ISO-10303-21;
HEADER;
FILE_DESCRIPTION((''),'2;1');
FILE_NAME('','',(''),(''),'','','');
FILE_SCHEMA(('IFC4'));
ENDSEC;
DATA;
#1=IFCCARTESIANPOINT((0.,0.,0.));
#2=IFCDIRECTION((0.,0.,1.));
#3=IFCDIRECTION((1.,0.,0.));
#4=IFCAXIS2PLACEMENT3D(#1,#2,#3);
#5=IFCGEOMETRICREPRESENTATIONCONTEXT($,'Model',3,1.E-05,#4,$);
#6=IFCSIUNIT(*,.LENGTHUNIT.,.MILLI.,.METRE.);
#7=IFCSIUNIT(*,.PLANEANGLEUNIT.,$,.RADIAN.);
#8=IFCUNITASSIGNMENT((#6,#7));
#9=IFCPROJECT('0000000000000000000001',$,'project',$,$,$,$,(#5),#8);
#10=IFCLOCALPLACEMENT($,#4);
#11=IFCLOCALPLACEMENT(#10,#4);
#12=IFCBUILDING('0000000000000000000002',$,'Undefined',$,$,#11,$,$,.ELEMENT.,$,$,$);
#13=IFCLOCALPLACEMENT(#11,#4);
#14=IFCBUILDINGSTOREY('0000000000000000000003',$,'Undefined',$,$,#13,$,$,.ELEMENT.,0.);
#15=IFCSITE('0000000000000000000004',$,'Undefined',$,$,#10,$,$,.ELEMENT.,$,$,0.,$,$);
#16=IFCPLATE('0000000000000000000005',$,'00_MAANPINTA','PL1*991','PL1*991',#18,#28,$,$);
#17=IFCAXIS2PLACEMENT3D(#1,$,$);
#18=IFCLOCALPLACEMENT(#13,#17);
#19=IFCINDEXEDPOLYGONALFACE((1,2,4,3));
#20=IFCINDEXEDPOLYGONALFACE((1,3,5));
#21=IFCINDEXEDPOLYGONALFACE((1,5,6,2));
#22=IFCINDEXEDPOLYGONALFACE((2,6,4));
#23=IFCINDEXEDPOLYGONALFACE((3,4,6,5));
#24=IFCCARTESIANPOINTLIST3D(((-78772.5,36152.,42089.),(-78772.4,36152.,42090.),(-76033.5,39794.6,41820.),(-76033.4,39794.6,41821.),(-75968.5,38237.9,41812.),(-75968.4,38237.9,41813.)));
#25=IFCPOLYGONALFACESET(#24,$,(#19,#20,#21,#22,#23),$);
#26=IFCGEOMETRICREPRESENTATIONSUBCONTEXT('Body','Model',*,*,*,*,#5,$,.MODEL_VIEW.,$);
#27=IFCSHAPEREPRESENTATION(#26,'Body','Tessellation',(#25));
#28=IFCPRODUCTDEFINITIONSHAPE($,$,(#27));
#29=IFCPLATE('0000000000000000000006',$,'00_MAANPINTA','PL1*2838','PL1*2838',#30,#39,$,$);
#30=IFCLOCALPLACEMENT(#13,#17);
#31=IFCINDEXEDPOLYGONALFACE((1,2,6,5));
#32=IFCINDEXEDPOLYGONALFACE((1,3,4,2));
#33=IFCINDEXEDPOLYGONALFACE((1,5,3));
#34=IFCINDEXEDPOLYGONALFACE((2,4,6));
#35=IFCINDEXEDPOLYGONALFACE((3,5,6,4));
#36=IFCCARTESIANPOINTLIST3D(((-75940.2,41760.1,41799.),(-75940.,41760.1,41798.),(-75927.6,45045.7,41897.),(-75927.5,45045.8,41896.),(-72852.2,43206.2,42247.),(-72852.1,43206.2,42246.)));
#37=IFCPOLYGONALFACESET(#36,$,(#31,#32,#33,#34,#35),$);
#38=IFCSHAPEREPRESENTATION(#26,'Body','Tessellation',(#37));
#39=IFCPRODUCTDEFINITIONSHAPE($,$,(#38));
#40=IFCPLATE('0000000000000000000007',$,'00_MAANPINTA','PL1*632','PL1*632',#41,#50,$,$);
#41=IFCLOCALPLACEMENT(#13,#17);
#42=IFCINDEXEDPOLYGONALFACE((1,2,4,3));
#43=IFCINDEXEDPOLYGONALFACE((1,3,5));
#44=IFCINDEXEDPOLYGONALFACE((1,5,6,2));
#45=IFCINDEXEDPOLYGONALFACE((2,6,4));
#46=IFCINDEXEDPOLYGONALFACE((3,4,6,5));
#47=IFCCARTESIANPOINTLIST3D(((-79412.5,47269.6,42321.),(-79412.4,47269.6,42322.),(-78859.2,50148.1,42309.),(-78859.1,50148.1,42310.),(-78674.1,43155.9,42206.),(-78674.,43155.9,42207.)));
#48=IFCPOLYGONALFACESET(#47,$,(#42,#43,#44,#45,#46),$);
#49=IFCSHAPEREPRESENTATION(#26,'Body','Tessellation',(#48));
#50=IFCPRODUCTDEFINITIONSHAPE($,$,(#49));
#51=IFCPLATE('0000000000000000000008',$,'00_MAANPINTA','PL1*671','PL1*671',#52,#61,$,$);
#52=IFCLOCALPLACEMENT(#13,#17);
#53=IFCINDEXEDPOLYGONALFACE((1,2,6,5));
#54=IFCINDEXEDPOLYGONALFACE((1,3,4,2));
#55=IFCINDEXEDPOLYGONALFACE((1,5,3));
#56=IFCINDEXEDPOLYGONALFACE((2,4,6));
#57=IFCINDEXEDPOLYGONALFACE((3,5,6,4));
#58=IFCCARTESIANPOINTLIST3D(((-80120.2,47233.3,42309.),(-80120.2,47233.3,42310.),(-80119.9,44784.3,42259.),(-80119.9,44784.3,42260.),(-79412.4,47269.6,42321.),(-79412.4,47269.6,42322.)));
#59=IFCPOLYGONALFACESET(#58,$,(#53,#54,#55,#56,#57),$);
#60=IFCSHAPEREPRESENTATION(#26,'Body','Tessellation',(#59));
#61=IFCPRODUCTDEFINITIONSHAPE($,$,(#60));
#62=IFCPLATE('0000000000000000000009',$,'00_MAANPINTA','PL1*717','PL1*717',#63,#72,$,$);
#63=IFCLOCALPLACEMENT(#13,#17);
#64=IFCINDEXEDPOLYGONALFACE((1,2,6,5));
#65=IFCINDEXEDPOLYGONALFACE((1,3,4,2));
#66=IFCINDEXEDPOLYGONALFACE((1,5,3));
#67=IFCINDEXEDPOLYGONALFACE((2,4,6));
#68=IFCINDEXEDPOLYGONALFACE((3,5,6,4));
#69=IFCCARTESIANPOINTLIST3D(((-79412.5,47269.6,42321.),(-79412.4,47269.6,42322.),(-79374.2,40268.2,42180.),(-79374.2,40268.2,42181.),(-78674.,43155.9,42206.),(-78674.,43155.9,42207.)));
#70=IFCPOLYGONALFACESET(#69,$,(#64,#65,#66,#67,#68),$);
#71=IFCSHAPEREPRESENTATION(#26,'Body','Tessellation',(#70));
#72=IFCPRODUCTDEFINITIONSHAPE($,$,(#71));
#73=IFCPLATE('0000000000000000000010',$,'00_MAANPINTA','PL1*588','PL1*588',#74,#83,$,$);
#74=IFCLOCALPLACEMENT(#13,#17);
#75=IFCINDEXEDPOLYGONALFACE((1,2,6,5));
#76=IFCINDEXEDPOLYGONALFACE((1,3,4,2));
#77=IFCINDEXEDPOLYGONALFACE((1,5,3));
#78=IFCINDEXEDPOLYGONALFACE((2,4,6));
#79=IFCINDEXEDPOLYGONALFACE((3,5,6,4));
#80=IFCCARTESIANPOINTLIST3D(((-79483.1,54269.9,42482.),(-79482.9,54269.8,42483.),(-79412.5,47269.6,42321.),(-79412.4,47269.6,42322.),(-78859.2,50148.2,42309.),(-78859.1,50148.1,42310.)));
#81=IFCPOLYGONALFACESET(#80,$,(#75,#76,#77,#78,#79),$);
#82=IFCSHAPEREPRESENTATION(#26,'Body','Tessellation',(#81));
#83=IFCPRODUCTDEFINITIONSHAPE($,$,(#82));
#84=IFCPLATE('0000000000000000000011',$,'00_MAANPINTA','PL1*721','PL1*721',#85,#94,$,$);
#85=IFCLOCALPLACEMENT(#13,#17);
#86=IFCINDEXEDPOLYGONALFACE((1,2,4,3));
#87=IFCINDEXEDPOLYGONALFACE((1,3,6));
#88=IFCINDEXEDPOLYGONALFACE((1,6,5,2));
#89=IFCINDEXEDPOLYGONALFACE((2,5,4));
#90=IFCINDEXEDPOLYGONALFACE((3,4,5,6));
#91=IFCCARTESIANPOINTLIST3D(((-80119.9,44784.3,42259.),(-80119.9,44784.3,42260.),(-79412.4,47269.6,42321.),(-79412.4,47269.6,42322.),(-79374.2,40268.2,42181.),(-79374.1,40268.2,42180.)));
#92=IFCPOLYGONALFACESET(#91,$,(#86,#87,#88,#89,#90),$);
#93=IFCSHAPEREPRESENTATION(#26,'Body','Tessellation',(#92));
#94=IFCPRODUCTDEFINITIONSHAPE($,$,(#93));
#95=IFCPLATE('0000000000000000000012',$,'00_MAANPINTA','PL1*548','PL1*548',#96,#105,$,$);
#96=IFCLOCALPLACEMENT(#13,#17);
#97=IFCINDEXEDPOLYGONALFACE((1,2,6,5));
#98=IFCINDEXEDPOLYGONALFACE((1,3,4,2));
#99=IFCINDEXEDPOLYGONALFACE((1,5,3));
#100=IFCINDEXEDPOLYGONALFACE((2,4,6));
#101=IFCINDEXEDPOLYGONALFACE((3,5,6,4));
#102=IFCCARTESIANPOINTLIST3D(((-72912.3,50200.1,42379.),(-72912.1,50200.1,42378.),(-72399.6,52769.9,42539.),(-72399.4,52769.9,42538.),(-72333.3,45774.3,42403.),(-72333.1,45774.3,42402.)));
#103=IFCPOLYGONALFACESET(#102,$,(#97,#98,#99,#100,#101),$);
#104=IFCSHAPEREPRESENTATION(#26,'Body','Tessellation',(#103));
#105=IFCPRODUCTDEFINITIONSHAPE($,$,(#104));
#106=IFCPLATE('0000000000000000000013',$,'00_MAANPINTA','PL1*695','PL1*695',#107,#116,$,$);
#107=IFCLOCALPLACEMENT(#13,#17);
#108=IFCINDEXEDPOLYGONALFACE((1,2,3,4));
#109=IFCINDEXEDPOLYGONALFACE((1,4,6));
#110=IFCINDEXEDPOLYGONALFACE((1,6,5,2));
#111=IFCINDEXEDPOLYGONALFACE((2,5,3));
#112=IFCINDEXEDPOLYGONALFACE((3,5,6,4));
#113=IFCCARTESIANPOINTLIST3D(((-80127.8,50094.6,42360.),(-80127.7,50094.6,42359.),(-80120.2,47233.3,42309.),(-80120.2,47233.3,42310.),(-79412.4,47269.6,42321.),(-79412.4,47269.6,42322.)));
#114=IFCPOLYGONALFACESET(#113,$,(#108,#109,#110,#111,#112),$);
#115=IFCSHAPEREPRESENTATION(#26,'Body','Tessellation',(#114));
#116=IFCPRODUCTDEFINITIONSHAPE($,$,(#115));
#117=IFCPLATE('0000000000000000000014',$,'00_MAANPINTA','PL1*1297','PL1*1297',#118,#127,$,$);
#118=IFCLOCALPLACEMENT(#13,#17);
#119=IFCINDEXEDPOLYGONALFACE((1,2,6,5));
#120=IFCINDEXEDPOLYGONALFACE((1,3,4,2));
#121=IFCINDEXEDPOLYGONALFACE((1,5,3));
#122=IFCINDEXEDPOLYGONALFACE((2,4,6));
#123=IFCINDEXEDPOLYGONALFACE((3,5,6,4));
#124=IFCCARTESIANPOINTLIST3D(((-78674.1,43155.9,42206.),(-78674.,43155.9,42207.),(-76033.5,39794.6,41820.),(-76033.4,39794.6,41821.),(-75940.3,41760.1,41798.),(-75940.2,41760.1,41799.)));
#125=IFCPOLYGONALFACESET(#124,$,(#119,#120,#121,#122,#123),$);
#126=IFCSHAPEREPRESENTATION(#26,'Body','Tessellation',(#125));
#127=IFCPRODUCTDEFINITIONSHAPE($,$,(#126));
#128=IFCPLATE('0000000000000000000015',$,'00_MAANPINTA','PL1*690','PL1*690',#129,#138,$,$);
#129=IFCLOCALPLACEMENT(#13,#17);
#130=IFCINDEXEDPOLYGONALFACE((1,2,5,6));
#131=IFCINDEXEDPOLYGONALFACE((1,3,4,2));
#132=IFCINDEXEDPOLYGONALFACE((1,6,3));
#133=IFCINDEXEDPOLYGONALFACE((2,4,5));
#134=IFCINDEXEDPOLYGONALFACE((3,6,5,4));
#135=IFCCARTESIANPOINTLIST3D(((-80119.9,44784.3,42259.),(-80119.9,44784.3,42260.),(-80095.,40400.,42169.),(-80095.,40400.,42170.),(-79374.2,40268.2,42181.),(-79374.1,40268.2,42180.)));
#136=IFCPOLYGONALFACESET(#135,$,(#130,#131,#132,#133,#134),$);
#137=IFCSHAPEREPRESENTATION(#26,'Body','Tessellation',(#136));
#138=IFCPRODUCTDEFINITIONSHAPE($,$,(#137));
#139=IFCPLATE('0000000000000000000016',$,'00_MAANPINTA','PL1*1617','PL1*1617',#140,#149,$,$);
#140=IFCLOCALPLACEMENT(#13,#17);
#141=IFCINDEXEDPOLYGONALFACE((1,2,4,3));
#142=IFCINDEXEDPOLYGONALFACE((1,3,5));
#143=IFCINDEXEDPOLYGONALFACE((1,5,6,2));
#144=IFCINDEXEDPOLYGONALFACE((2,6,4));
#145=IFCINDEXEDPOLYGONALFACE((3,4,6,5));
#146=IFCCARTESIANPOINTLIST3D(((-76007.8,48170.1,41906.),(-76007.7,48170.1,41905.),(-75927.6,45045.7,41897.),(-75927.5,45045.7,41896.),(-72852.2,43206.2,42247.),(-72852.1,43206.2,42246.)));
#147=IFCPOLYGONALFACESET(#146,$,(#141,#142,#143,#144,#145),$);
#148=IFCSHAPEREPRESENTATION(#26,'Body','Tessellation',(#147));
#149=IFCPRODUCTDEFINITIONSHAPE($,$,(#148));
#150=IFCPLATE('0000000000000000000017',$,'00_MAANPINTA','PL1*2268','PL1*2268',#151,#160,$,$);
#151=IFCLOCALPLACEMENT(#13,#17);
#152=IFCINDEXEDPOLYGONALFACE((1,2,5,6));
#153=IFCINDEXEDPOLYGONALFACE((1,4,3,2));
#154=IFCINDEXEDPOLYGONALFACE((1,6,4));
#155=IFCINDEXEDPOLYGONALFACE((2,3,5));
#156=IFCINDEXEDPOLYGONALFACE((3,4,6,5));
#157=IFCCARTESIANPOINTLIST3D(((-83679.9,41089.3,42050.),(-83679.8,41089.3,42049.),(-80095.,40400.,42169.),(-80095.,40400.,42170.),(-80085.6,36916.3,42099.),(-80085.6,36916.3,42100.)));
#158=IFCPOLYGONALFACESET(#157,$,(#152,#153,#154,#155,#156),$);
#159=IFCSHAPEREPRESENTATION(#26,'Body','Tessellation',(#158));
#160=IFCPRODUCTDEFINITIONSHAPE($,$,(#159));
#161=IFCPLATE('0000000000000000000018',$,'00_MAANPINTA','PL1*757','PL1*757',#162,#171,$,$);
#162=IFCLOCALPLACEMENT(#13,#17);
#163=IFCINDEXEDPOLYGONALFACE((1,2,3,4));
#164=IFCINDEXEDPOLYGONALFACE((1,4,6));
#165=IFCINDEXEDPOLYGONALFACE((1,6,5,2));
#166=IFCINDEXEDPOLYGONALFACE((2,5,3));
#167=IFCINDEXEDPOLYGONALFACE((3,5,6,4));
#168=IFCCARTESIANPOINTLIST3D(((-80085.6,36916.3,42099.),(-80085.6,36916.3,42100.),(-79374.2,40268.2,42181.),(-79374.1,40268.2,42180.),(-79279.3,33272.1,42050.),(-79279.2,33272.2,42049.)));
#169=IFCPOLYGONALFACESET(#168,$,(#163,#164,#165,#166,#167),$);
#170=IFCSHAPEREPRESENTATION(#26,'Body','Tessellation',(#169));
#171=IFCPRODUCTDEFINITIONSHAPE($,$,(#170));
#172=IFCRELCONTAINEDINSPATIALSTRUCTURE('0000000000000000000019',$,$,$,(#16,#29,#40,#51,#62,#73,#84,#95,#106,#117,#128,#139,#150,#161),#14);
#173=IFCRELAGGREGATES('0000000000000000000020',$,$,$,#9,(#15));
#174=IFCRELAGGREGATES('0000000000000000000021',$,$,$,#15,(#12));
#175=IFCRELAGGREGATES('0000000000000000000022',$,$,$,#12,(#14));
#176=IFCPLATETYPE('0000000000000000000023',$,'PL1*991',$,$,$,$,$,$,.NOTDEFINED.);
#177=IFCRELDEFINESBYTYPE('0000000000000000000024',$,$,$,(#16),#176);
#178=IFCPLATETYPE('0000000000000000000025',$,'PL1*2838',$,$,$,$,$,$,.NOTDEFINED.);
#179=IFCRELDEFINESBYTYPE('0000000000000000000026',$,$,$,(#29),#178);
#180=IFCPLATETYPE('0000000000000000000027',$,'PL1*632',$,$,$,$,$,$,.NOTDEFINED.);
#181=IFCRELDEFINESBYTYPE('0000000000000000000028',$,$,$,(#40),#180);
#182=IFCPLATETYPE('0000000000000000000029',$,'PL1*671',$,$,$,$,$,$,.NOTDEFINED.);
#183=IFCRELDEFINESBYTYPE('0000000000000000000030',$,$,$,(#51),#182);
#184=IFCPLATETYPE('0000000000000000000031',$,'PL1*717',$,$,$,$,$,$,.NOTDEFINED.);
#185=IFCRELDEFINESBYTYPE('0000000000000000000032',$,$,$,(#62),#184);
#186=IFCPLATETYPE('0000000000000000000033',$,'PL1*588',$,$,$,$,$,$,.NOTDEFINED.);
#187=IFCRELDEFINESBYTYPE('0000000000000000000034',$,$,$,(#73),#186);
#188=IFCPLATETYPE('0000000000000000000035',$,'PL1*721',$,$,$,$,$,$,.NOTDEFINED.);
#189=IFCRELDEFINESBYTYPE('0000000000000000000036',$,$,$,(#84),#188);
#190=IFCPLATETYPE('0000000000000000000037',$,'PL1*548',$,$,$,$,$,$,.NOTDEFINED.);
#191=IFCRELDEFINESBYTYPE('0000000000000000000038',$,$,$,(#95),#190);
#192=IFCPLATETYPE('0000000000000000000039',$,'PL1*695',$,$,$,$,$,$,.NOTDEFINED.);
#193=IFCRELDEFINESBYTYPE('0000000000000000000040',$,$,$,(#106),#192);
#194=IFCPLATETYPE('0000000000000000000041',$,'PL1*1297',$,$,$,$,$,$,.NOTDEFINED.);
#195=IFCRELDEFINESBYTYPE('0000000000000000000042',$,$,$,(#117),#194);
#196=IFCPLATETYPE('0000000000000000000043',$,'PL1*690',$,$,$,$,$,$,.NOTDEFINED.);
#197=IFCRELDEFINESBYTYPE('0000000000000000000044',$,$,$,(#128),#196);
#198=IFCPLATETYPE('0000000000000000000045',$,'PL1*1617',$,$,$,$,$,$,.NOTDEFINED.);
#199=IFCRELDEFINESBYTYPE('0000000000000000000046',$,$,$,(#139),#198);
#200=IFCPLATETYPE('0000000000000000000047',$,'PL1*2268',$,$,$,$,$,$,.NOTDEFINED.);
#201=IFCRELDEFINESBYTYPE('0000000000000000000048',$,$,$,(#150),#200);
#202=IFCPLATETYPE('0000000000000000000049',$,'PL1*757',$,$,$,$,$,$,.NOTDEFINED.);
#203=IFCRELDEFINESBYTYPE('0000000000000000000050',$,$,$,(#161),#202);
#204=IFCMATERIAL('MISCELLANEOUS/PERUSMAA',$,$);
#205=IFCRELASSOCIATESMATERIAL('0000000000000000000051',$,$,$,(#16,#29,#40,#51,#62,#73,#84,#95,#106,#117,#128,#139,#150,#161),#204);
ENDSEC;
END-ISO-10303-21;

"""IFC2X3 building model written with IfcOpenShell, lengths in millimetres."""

from ifc_helpers import new_model, si_unit, frame, origin_with_axes, place, context, subcontext, project, spatial, polyline, outline, extrude, material, type_object, element, save


model = new_model("IFC2X3")

# Units and contexts
model_context = context("Model", 3, precision=1e-05, world=origin_with_axes())
body_context = subcontext(model_context, "Body", "Model", "MODEL_VIEW")
ifc_project = project(units=[si_unit("LENGTHUNIT", "METRE", prefix="MILLI"), si_unit("PLANEANGLEUNIT", "RADIAN")], contexts=[model_context])

# Site, building, storey
site_placement = place(None, origin_with_axes())
site = spatial("IfcSite", under=ifc_project, at=site_placement, Name="Undefined", CompositionType="ELEMENT", RefElevation=0.0)
building_placement = place(site_placement, origin_with_axes())
building = spatial("IfcBuilding", under=site, at=building_placement, Name="Undefined", CompositionType="ELEMENT")
storey_placement = place(building_placement, origin_with_axes())
storey = spatial("IfcBuildingStorey", under=building, at=storey_placement, Name="Undefined", CompositionType="ELEMENT", Elevation=0.0)

# Plates
ifc_material = material(Name="MISCELLANEOUS/PERUSMAA")
plate_type_1 = type_object("IfcPlateType", Name="PL1*991", PredefinedType="NOTDEFINED")
plate_1_placement = place(storey_placement, frame((-76033.4, 39794.6, 41820.5), z_axis=(-0.099031, 0.000981, -0.995084), x_axis=(0.041701, -0.999117, -0.005135)))
element("IfcPlate", 1, at=plate_1_placement, inside=storey, type_object=plate_type_1, material=ifc_material, Name="00_MAANPINTA", Description="PL1*991", ObjectType="PL1*991", context=body_context, shape_type="SweptSolid", body=[
    extrude(outline(polyline([(0.0, 0.0), (1558.0, 0.0), (3523.7, 2902.8), (0.0, 0.0)])), frame((0.0, 0.0, -0.5), z_axis=(0.0, 0.0, 1.0), x_axis=(1.0, 0.0, 0.0)), (0.0, 0.0, 1.0), 1.0),
])
plate_type_2 = type_object("IfcPlateType", Name="PL1*2838", PredefinedType="NOTDEFINED")
plate_2_placement = place(storey_placement, frame((-75940.1, 41760.1, 41798.5), z_axis=(0.130172, 0.029063, -0.991065), x_axis=(0.003816, 0.999548, 0.029813)))
element("IfcPlate", 2, at=plate_2_placement, inside=storey, type_object=plate_type_2, material=ifc_material, Name="00_MAANPINTA", Description="PL1*2838", ObjectType="PL1*2838", context=body_context, shape_type="SweptSolid", body=[
    extrude(outline(polyline([(0.0, 0.0), (3287.1, 0.0), (1470.6, 3108.8), (0.0, 0.0)])), frame((0.0, 0.0, -0.5), z_axis=(0.0, 0.0, 1.0), x_axis=(1.0, 0.0, 0.0)), (0.0, 0.0, 1.0), 1.0),
])
plate_type_3 = type_object("IfcPlateType", Name="PL1*632", PredefinedType="NOTDEFINED")
plate_3_placement = place(storey_placement, frame((-78674.0, 43155.9, 42206.5), z_axis=(-0.086091, 0.012396, -0.99621), x_axis=(-0.176609, 0.983897, 0.027505)))
element("IfcPlate", 3, at=plate_3_placement, inside=storey, type_object=plate_type_3, material=ifc_material, Name="00_MAANPINTA", Description="PL1*632", ObjectType="PL1*632", context=body_context, shape_type="SweptSolid", body=[
    extrude(outline(polyline([(0.0, 0.0), (4181.0, 0.0), (6915.2, 1056.8), (0.0, 0.0)])), frame((0.0, 0.0, -0.5), z_axis=(0.0, 0.0, 1.0), x_axis=(1.0, 0.0, 0.0)), (0.0, 0.0, 1.0), 1.0),
])
plate_type_4 = type_object("IfcPlateType", Name="PL1*671", PredefinedType="NOTDEFINED")
plate_4_placement = place(storey_placement, frame((-80120.2, 47233.3, 42309.5), z_axis=(0.015903, 0.020411, -0.999665), x_axis=(0.998546, 0.051185, 0.01693)))
element("IfcPlate", 4, at=plate_4_placement, inside=storey, type_object=plate_type_4, material=ifc_material, Name="00_MAANPINTA", Description="PL1*671", ObjectType="PL1*671", context=body_context, shape_type="SweptSolid", body=[
    extrude(outline(polyline([(0.0, 0.0), (708.8, 0.0), (-125.9, 2446.3), (0.0, 0.0)])), frame((0.0, 0.0, -0.5), z_axis=(0.0, 0.0, 1.0), x_axis=(1.0, 0.0, 0.0)), (0.0, 0.0, 1.0), 1.0),
])
plate_type_5 = type_object("IfcPlateType", Name="PL1*717", PredefinedType="NOTDEFINED")
plate_5_placement = place(storey_placement, frame((-79374.2, 40268.2, 42180.5), z_axis=(-0.044859, 0.01987, -0.998796), x_axis=(-0.005461, 0.999782, 0.020134)))
element("IfcPlate", 5, at=plate_5_placement, inside=storey, type_object=plate_type_5, material=ifc_material, Name="00_MAANPINTA", Description="PL1*717", ObjectType="PL1*717", context=body_context, shape_type="SweptSolid", body=[
    extrude(outline(polyline([(0.0, 0.0), (7002.9, 0.0), (2883.8, 716.6), (0.0, 0.0)])), frame((0.0, 0.0, -0.5), z_axis=(0.0, 0.0, 1.0), x_axis=(1.0, 0.0, 0.0)), (0.0, 0.0, 1.0), 1.0),
])
plate_type_6 = type_object("IfcPlateType", Name="PL1*588", PredefinedType="NOTDEFINED")
plate_6_placement = place(storey_placement, frame((-79412.5, 47269.6, 42321.5), z_axis=(-0.133069, 0.021449, -0.990875), x_axis=(-0.010072, 0.999685, 0.022992)))
element("IfcPlate", 6, at=plate_6_placement, inside=storey, type_object=plate_type_6, material=ifc_material, Name="00_MAANPINTA", Description="PL1*588", ObjectType="PL1*588", context=body_context, shape_type="SweptSolid", body=[
    extrude(outline(polyline([(0.0, 0.0), (7002.5, 0.0), (2871.8, 587.5), (0.0, 0.0)])), frame((0.0, 0.0, -0.5), z_axis=(0.0, 0.0, 1.0), x_axis=(1.0, 0.0, 0.0)), (0.0, 0.0, 1.0), 1.0),
])
plate_type_7 = type_object("IfcPlateType", Name="PL1*721", PredefinedType="NOTDEFINED")
plate_7_placement = place(storey_placement, frame((-80119.9, 44784.3, 42259.5), z_axis=(0.016565, 0.020222, -0.999658), x_axis=(0.273717, 0.961511, 0.023987)))
element("IfcPlate", 7, at=plate_7_placement, inside=storey, type_object=plate_type_7, material=ifc_material, Name="00_MAANPINTA", Description="PL1*721", ObjectType="PL1*721", context=body_context, shape_type="SweptSolid", body=[
    extrude(outline(polyline([(0.0, 0.0), (2584.8, 0.0), (-4140.1, 1953.8), (0.0, 0.0)])), frame((0.0, 0.0, -0.5), z_axis=(0.0, 0.0, 1.0), x_axis=(1.0, 0.0, 0.0)), (0.0, 0.0, 1.0), 1.0),
])
plate_type_8 = type_object("IfcPlateType", Name="PL1*548", PredefinedType="NOTDEFINED")
plate_8_placement = place(storey_placement, frame((-72333.2, 45774.3, 42402.5), z_axis=(0.200681, 0.020942, -0.979433), x_axis=(-0.129715, 0.991537, -0.005377)))
element("IfcPlate", 8, at=plate_8_placement, inside=storey, type_object=plate_type_8, material=ifc_material, Name="00_MAANPINTA", Description="PL1*548", ObjectType="PL1*548", context=body_context, shape_type="SweptSolid", body=[
    extrude(outline(polyline([(0.0, 0.0), (4463.6, 0.0), (6944.2, 859.4), (0.0, 0.0)])), frame((0.0, 0.0, -0.5), z_axis=(0.0, 0.0, 1.0), x_axis=(1.0, 0.0, 0.0)), (0.0, 0.0, 1.0), 1.0),
])
plate_type_9 = type_object("IfcPlateType", Name="PL1*695", PredefinedType="NOTDEFINED")
plate_9_placement = place(storey_placement, frame((-79412.4, 47269.6, 42321.5), z_axis=(0.016052, 0.017512, -0.999718), x_axis=(-0.998546, -0.051185, -0.01693)))
element("IfcPlate", 9, at=plate_9_placement, inside=storey, type_object=plate_type_9, material=ifc_material, Name="00_MAANPINTA", Description="PL1*695", ObjectType="PL1*695", context=body_context, shape_type="SweptSolid", body=[
    extrude(outline(polyline([(0.0, 0.0), (708.8, 0.0), (569.1, 2858.3), (0.0, 0.0)])), frame((0.0, 0.0, -0.5), z_axis=(0.0, 0.0, 1.0), x_axis=(1.0, 0.0, 0.0)), (0.0, 0.0, 1.0), 1.0),
])
plate_type_10 = type_object("IfcPlateType", Name="PL1*1297", PredefinedType="NOTDEFINED")
plate_10_placement = place(storey_placement, frame((-75940.2, 41760.1, 41798.5), z_axis=(-0.149589, -0.003973, -0.98874), x_axis=(-0.047366, -0.998815, 0.01118)))
element("IfcPlate", 10, at=plate_10_placement, inside=storey, type_object=plate_type_10, material=ifc_material, Name="00_MAANPINTA", Description="PL1*1297", ObjectType="PL1*1297", context=body_context, shape_type="SweptSolid", body=[
    extrude(outline(polyline([(0.0, 0.0), (1967.9, 0.0), (-1260.1, 2828.5), (0.0, 0.0)])), frame((0.0, 0.0, -0.5), z_axis=(0.0, 0.0, 1.0), x_axis=(1.0, 0.0, 0.0)), (0.0, 0.0, 1.0), 1.0),
])
plate_type_11 = type_object("IfcPlateType", Name="PL1*690", PredefinedType="NOTDEFINED")
plate_11_placement = place(storey_placement, frame((-79374.2, 40268.2, 42180.5), z_axis=(0.019025, 0.020628, -0.999606), x_axis=(-0.983585, 0.179821, -0.015009)))
element("IfcPlate", 11, at=plate_11_placement, inside=storey, type_object=plate_type_11, material=ifc_material, Name="00_MAANPINTA", Description="PL1*690", ObjectType="PL1*690", context=body_context, shape_type="SweptSolid", body=[
    extrude(outline(polyline([(0.0, 0.0), (732.9, 0.0), (1544.4, 4309.6), (0.0, 0.0)])), frame((0.0, 0.0, -0.5), z_axis=(0.0, 0.0, 1.0), x_axis=(1.0, 0.0, 0.0)), (0.0, 0.0, 1.0), 1.0),
])
plate_type_12 = type_object("IfcPlateType", Name="PL1*1617", PredefinedType="NOTDEFINED")
plate_12_placement = place(storey_placement, frame((-72852.1, 43206.2, 42246.5), z_axis=(0.116528, 0.005851, -0.99317), x_axis=(-0.85413, 0.510894, -0.097204)))
element("IfcPlate", 12, at=plate_12_placement, inside=storey, type_object=plate_type_12, material=ifc_material, Name="00_MAANPINTA", Description="PL1*1617", ObjectType="PL1*1617", context=body_context, shape_type="SweptSolid", body=[
    extrude(outline(polyline([(0.0, 0.0), (3600.7, 0.0), (5264.5, 2645.7), (0.0, 0.0)])), frame((0.0, 0.0, -0.5), z_axis=(0.0, 0.0, 1.0), x_axis=(1.0, 0.0, 0.0)), (0.0, 0.0, 1.0), 1.0),
])
plate_type_13 = type_object("IfcPlateType", Name="PL1*2268", PredefinedType="NOTDEFINED")
plate_13_placement = place(storey_placement, frame((-83679.8, 41089.3, 42049.5), z_axis=(0.037324, 0.020176, -0.9991), x_axis=(0.981479, -0.188734, 0.032854)))
element("IfcPlate", 13, at=plate_13_placement, inside=storey, type_object=plate_type_13, material=ifc_material, Name="00_MAANPINTA", Description="PL1*2268", ObjectType="PL1*2268", context=body_context, shape_type="SweptSolid", body=[
    extrude(outline(polyline([(0.0, 0.0), (3652.5, 0.0), (4316.9, 3420.5), (0.0, 0.0)])), frame((0.0, 0.0, -0.5), z_axis=(0.0, 0.0, 1.0), x_axis=(1.0, 0.0, 0.0)), (0.0, 0.0, 1.0), 1.0),
])
plate_type_14 = type_object("IfcPlateType", Name="PL1*757", PredefinedType="NOTDEFINED")
plate_14_placement = place(storey_placement, frame((-79374.2, 40268.2, 42180.5), z_axis=(0.024082, 0.019043, -0.999529), x_axis=(0.013562, -0.999733, -0.01872)))
element("IfcPlate", 14, at=plate_14_placement, inside=storey, type_object=plate_type_14, material=ifc_material, Name="00_MAANPINTA", Description="PL1*757", ObjectType="PL1*757", context=body_context, shape_type="SweptSolid", body=[
    extrude(outline(polyline([(0.0, 0.0), (6997.9, 0.0), (3342.9, 757.1), (0.0, 0.0)])), frame((0.0, 0.0, -0.5), z_axis=(0.0, 0.0, 1.0), x_axis=(1.0, 0.0, 0.0)), (0.0, 0.0, 1.0), 1.0),
])

save(model, "model.ifc")
